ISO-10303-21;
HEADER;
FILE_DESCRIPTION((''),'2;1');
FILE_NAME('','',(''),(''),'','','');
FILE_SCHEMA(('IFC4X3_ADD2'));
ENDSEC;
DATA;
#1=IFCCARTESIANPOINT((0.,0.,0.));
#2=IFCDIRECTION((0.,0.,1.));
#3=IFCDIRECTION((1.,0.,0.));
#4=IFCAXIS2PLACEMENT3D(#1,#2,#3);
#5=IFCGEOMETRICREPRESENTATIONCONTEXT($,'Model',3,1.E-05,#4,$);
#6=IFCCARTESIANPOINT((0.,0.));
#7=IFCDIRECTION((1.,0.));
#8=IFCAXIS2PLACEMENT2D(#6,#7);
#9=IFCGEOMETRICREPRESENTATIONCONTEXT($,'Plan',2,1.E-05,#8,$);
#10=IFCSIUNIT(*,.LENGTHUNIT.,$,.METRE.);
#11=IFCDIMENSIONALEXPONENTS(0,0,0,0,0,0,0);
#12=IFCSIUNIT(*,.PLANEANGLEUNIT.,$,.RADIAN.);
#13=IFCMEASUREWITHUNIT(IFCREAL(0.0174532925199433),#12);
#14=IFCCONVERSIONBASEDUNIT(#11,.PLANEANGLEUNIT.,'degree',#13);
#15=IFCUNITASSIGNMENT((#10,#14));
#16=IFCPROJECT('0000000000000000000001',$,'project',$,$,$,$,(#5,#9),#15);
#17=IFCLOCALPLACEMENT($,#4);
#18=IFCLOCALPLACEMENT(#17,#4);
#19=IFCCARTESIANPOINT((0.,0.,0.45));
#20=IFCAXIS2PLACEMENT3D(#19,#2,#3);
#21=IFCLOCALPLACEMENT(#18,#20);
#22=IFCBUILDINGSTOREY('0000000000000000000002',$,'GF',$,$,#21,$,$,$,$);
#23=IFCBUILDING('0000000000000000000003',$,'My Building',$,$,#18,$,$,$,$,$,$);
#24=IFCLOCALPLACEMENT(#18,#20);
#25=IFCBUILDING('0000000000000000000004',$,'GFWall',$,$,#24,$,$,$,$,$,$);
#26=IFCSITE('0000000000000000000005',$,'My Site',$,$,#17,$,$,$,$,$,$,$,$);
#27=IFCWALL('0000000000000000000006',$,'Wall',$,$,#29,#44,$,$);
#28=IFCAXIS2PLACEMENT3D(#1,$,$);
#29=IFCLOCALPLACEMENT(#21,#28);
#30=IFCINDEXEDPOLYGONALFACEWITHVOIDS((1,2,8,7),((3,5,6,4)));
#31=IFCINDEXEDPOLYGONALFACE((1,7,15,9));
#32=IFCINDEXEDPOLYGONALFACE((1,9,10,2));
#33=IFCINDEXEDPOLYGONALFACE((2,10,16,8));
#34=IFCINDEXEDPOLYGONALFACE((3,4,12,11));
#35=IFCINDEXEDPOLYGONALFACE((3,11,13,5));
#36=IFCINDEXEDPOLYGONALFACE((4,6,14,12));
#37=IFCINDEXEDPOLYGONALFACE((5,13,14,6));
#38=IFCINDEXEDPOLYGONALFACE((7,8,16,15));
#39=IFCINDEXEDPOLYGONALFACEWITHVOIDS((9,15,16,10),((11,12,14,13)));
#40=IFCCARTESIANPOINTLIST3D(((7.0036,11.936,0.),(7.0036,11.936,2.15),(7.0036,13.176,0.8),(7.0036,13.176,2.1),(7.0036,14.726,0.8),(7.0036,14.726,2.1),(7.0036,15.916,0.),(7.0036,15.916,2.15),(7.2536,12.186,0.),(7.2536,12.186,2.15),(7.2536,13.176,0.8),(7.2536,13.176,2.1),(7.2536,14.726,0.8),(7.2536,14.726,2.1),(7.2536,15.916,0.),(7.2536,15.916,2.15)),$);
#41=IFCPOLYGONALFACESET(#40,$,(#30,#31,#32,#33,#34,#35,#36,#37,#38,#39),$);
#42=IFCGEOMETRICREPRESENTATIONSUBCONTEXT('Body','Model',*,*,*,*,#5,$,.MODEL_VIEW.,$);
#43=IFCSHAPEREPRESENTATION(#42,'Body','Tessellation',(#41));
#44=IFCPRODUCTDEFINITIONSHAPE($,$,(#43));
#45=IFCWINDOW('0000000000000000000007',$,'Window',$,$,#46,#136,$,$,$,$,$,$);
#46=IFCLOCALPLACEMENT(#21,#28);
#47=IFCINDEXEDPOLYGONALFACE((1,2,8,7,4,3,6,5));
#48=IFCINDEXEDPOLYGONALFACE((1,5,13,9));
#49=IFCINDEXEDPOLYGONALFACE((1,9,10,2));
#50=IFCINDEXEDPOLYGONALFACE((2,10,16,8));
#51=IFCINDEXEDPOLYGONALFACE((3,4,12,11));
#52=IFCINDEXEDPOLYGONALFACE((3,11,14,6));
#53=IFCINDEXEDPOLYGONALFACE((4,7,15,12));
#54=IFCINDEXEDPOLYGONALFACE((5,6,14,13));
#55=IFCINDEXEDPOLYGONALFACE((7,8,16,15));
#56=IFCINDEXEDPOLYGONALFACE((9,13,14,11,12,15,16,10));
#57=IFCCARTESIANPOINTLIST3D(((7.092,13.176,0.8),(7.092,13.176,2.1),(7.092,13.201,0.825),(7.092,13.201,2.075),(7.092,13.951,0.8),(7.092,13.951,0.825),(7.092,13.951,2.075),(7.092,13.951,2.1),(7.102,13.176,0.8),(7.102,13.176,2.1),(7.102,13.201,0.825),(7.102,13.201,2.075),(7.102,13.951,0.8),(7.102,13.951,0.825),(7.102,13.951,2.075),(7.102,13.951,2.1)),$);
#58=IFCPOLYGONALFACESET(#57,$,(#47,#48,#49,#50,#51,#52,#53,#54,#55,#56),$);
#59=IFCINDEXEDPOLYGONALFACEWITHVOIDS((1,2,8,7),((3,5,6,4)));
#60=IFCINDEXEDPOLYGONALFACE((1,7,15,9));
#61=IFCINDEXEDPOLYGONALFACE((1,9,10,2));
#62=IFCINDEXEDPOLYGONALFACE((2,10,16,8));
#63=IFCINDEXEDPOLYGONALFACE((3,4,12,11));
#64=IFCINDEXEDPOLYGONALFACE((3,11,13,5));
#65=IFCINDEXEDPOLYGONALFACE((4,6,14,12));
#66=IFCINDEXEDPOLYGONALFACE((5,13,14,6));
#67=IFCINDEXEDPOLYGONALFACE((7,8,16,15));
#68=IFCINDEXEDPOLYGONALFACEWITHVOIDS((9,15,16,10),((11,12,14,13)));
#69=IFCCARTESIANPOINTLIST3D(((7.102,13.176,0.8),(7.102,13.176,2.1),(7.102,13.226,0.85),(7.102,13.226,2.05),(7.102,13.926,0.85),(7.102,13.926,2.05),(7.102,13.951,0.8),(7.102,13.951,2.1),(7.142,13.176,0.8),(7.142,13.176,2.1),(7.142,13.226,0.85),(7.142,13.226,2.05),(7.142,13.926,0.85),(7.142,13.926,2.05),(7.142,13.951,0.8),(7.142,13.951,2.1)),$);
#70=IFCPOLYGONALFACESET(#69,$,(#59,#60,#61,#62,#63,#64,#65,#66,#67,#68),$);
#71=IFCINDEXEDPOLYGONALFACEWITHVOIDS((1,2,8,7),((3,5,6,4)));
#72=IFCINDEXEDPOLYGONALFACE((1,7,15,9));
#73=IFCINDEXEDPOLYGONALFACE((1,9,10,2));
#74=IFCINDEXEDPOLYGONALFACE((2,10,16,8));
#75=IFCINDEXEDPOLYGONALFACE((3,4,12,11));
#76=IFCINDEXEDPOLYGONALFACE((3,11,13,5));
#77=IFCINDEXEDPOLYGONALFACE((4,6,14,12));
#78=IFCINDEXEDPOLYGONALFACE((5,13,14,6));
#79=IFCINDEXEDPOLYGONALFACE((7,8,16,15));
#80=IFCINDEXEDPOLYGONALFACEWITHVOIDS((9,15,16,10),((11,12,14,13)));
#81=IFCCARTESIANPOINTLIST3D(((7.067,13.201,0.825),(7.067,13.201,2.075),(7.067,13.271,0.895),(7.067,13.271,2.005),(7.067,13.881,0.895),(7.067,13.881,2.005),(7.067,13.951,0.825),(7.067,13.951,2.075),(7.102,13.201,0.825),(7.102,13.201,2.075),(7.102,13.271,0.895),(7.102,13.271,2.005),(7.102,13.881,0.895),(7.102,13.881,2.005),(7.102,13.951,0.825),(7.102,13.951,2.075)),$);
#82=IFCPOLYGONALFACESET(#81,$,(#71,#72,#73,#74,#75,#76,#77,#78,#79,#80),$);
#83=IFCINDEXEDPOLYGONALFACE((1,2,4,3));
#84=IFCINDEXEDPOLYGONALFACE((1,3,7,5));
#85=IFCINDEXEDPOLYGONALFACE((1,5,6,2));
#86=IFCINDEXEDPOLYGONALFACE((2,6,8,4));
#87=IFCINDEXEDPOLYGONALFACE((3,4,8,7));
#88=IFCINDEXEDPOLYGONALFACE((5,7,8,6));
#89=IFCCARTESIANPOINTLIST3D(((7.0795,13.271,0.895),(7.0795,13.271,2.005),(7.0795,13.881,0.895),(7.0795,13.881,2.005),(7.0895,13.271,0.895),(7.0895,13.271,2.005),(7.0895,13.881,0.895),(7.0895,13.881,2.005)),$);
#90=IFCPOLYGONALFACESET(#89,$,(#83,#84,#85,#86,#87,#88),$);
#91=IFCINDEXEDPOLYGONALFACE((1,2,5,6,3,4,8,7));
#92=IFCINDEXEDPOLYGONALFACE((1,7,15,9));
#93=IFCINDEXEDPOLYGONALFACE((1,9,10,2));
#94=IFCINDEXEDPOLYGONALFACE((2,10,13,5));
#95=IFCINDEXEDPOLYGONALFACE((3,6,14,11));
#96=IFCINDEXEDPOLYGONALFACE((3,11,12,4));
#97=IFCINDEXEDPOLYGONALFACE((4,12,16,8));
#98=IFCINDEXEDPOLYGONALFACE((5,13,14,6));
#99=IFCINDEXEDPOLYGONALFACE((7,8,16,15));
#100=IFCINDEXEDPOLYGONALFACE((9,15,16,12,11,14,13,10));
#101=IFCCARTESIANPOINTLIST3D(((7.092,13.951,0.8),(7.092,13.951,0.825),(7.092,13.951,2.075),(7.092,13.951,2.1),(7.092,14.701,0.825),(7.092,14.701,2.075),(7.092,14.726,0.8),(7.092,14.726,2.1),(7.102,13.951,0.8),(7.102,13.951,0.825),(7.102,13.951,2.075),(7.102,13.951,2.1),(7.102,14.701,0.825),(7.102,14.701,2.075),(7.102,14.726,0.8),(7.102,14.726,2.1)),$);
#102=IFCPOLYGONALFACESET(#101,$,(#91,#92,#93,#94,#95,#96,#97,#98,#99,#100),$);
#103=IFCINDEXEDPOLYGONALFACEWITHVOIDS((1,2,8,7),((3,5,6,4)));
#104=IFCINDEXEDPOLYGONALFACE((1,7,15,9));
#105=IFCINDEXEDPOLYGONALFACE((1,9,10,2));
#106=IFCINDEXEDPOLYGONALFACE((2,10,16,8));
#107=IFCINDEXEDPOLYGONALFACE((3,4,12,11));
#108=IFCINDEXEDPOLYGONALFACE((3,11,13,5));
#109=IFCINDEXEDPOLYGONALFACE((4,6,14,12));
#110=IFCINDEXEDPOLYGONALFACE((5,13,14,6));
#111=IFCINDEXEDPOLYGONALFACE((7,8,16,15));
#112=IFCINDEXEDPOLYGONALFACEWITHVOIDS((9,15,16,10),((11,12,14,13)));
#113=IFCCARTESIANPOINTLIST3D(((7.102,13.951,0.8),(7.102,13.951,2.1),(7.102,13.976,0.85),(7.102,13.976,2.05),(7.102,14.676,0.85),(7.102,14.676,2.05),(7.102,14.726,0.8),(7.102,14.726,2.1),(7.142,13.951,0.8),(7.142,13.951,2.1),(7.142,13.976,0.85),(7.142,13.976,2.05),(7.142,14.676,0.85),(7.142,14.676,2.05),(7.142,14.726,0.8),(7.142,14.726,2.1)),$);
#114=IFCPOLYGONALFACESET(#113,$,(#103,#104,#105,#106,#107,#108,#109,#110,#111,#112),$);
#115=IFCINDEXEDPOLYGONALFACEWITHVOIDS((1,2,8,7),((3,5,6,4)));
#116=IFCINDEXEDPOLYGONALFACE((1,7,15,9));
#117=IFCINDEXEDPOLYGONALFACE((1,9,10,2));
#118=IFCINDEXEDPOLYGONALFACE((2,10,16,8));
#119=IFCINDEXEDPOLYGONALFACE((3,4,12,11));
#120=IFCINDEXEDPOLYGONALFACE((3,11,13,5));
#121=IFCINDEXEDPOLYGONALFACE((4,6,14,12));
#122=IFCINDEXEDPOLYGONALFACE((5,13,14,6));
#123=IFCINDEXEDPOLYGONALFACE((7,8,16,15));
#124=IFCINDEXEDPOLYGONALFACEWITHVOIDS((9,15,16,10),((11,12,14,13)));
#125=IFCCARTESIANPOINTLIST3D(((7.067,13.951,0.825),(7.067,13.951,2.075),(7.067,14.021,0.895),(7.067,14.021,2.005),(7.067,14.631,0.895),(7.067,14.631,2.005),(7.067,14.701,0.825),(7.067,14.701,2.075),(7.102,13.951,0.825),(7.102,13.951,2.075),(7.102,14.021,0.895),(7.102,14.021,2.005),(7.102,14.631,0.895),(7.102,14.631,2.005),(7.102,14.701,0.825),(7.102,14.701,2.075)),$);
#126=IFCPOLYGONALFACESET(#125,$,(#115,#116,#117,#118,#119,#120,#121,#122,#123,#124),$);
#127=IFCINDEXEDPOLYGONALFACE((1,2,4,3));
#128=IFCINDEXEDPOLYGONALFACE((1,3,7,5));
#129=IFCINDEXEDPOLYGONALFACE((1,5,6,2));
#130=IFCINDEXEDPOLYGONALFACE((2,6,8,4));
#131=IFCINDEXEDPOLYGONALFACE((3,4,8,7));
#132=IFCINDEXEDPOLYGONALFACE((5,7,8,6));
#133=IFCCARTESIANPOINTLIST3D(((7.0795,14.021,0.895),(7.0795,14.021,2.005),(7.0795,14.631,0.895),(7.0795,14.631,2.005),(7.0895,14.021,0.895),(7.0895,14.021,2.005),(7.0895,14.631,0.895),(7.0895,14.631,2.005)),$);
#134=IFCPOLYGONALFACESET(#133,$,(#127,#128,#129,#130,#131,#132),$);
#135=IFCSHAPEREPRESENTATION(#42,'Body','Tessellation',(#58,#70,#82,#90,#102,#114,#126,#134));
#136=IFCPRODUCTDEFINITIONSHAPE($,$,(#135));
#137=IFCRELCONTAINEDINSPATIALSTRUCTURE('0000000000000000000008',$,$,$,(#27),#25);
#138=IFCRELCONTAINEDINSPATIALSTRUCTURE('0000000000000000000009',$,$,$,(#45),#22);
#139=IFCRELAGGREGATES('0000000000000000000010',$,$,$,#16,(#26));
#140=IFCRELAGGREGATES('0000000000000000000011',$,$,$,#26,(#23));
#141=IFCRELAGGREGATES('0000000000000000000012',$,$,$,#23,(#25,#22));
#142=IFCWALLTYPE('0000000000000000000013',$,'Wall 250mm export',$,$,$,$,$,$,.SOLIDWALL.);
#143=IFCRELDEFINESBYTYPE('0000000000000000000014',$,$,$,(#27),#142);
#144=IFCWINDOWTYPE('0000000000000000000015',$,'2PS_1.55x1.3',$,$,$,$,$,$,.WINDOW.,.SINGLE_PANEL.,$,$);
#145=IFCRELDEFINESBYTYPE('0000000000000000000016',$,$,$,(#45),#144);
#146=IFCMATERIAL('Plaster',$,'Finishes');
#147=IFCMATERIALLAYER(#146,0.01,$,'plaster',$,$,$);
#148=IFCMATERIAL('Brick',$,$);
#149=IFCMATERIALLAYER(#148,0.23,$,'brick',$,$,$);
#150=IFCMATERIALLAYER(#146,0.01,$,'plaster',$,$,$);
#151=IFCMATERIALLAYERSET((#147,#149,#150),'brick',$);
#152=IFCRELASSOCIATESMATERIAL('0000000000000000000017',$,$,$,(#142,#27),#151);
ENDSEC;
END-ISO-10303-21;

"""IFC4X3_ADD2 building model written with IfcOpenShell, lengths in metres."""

from ifc_helpers import new_model, entity, si_unit, converted_unit, frame, origin_with_axes, origin_2d_with_axis, place, context, subcontext, project, spatial, line, indexed_curve, outline, extrude, shape, source, transform, mapped, material, layer, layer_set, layer_usage, type_object, type_shapes, element, fill, save


model = new_model("IFC4X3_ADD2")

# Units and contexts
model_context = context("Model", 3, precision=1e-05, world=origin_with_axes())
plan_context = context("Plan", 2, precision=1e-05, world=origin_2d_with_axis())
body_context_1 = subcontext(model_context, "Body", "Model", "MODEL_VIEW")
body_context_2 = subcontext(plan_context, "Body", "Plan", "PLAN_VIEW")
ifc_project = project(units=[si_unit("LENGTHUNIT", "METRE"), converted_unit("PLANEANGLEUNIT", "degree", entity("IfcReal", 0.0174532925199433), si_unit("PLANEANGLEUNIT", "RADIAN"), dimensions=[0, 0, 0, 0, 0, 0, 0])], contexts=[model_context, plan_context])

# Site, buildings
site_placement = place(None, origin_with_axes())
site = spatial("IfcSite", under=ifc_project, at=site_placement, Name="My Site")
building_1_placement = place(site_placement, origin_with_axes())
building_1 = spatial("IfcBuilding", under=site, at=building_1_placement, Name="My Building")
building_2_placement = place(building_1_placement, frame((0.0, 0.0, 0.45), z_axis=(0.0, 0.0, 1.0), x_axis=(1.0, 0.0, 0.0)))
building_2 = spatial("IfcBuilding", under=building_1, at=building_2_placement, Name="GFWall")

# Shared definitions
ifc_material_1 = material(Name="Plaster", Category="Finishes")

# Shared definitions
storey_placement = place(building_1_placement, frame((0.0, 0.0, 0.45), z_axis=(0.0, 0.0, 1.0), x_axis=(1.0, 0.0, 0.0)))
storey = spatial("IfcBuildingStorey", under=building_1, at=storey_placement, Name="GF")

# Shared definitions
ifc_layer_1 = layer(ifc_material_1, 0.01, Name="plaster")
ifc_material_2 = material(Name="Brick")
ifc_layer_2 = layer(ifc_material_2, 0.23, Name="brick")
ifc_layer_3 = layer(ifc_material_1, 0.01, Name="plaster")
ifc_layer_set_1 = layer_set([ifc_layer_1, ifc_layer_2, ifc_layer_3], Name="brick")
wall_type_1 = type_object("IfcWallType", Name="Wall 250mm export", PredefinedType="SOLIDWALL", material=ifc_layer_set_1)

# Wall, opening, window
ifc_layer_usage_1 = layer_usage(ifc_layer_set_1, "AXIS2", "POSITIVE", 0.0)
wall_1_placement = place(building_2_placement, frame((7.2536, 11.936, 0.0), z_axis=(0.0, 0.0, 1.0), x_axis=(0.0, 1.0, 0.0)))
wall_1 = element("IfcWall", 1, at=wall_1_placement, inside=building_2, type_object=wall_type_1, material=ifc_layer_usage_1, Name="Wall", context=body_context_1, shape_type="SweptSolid", body=[
    extrude(outline(indexed_curve([(0.25, 0.0), (0.0, 0.25), (3.98, 0.25), (3.98, 0.0)], segments=[line(1, 2, 3, 4, 1)])), origin_with_axes(), (0.0, 0.0, 1.0), 2.15),
])
shared_shape_1 = source(origin_with_axes(), body_context_1, "Body", "SweptSolid", [
    extrude(outline(indexed_curve([(0.0, 0.0), (1.55, 0.0), (1.55, 1.3), (0.0, 1.3)], segments=[line(1, 2, 3, 4, 1)])), frame((0.0, -0.6, 0.0), z_axis=(0.0, -1.0, 0.0), x_axis=(1.0, 0.0, 0.0)), (0.0, 0.0, -1.0), 1.2),
])
opening_1_placement = place(wall_1_placement, frame((1.24, 0.0616, 0.8), z_axis=(0.0, 0.0, 1.0), x_axis=(1.0, 0.0, 0.0)))
opening_1 = element("IfcOpeningElement", 2, at=opening_1_placement, cuts=wall_1, PredefinedType="OPENING", context=body_context_1, shape_type="MappedRepresentation", body=[
    mapped(shared_shape_1, transform((0.0, 0.0, 0.0), x_axis=(1.0, 0.0, 0.0), y_axis=(0.0, 1.0, 0.0), z_axis=(0.0, 0.0, 1.0), scale=1.0)),
])
window_type_1 = type_object("IfcWindowType", Name="2PS_1.55x1.3", PartitioningType="SINGLE_PANEL", PredefinedType="WINDOW")
shared_shape_2 = source(origin_with_axes(), body_context_1, "Body", "SweptSolid", [
    extrude(outline(indexed_curve([(0.775, 0.0), (0.0, 0.0), (0.0, 1.3), (0.775, 1.3), (0.775, 1.275), (0.025, 1.275), (0.025, 0.025), (0.775, 0.025)], segments=[line(1, 2, 3, 4, 5, 6, 7, 8, 1)])), frame((0.0, 0.09, 0.0), z_axis=(0.0, -1.0, 0.0), x_axis=(1.0, 0.0, 0.0)), (0.0, 0.0, -1.0), 0.01),
    extrude(outline(indexed_curve([(0.0, 0.0), (0.775, 0.0), (0.775, 1.3), (0.0, 1.3)], segments=[line(1, 2, 3, 4, 1)]), holes=[indexed_curve([(0.05, 0.05), (0.75, 0.05), (0.75, 1.25), (0.05, 1.25)], segments=[line(1, 2, 3, 4, 1)])]), frame((0.0, 0.05, 0.0), z_axis=(0.0, -1.0, 0.0), x_axis=(1.0, 0.0, 0.0)), (0.0, 0.0, -1.0), 0.04),
    extrude(outline(indexed_curve([(0.0, 0.0), (0.75, 0.0), (0.75, 1.25), (0.0, 1.25)], segments=[line(1, 2, 3, 4, 1)]), holes=[indexed_curve([(0.07, 0.07), (0.68, 0.07), (0.68, 1.18), (0.07, 1.18)], segments=[line(1, 2, 3, 4, 1)])]), frame((0.025, 0.09, 0.025), z_axis=(0.0, -1.0, 0.0), x_axis=(1.0, 0.0, 0.0)), (0.0, 0.0, -1.0), 0.035),
    extrude(outline(indexed_curve([(0.07, 0.07), (0.68, 0.07), (0.68, 1.18), (0.07, 1.18)], segments=[line(1, 2, 3, 4, 1)])), frame((0.025, 0.1025, 0.025), z_axis=(0.0, -1.0, 0.0), x_axis=(1.0, 0.0, 0.0)), (0.0, 0.0, -1.0), 0.01),
    extrude(outline(indexed_curve([(0.0, 1.3), (0.775, 1.3), (0.775, 0.0), (0.0, 0.0), (0.0, 0.025), (0.75, 0.025), (0.75, 1.275), (0.0, 1.275)], segments=[line(1, 2, 3, 4, 5, 6, 7, 8, 1)])), frame((0.775, 0.09, 0.0), z_axis=(0.0, -1.0, 0.0), x_axis=(1.0, 0.0, 0.0)), (0.0, 0.0, -1.0), 0.01),
    extrude(outline(indexed_curve([(0.0, 0.0), (0.775, 0.0), (0.775, 1.3), (0.0, 1.3)], segments=[line(1, 2, 3, 4, 1)]), holes=[indexed_curve([(0.025, 0.05), (0.725, 0.05), (0.725, 1.25), (0.025, 1.25)], segments=[line(1, 2, 3, 4, 1)])]), frame((0.775, 0.05, 0.0), z_axis=(0.0, -1.0, 0.0), x_axis=(1.0, 0.0, 0.0)), (0.0, 0.0, -1.0), 0.04),
    extrude(outline(indexed_curve([(0.0, 0.0), (0.75, 0.0), (0.75, 1.25), (0.0, 1.25)], segments=[line(1, 2, 3, 4, 1)]), holes=[indexed_curve([(0.07, 0.07), (0.68, 0.07), (0.68, 1.18), (0.07, 1.18)], segments=[line(1, 2, 3, 4, 1)])]), frame((0.775, 0.09, 0.025), z_axis=(0.0, -1.0, 0.0), x_axis=(1.0, 0.0, 0.0)), (0.0, 0.0, -1.0), 0.035),
    extrude(outline(indexed_curve([(0.07, 0.07), (0.68, 0.07), (0.68, 1.18), (0.07, 1.18)], segments=[line(1, 2, 3, 4, 1)])), frame((0.775, 0.1025, 0.025), z_axis=(0.0, -1.0, 0.0), x_axis=(1.0, 0.0, 0.0)), (0.0, 0.0, -1.0), 0.01),
])
shared_shape_3 = source(origin_with_axes(), body_context_2, "Body", "Curve2D", [
    entity("IfcIndexedPolyCurve", entity("IfcCartesianPointList2D", [[0.05, 0.05], [0.75, 0.05]])),
    entity("IfcIndexedPolyCurve", entity("IfcCartesianPointList2D", [[0.0, 0.1], [0.025, 0.1], [0.025, 0.09], [0.05, 0.09], [0.05, 0.05], [0.0, 0.05]]), [entity("IfcLineIndex", [1, 2, 3, 4, 5, 6, 1])]),
    entity("IfcIndexedPolyCurve", entity("IfcCartesianPointList2D", [[0.775, 0.1], [0.775, 0.1], [0.775, 0.09], [0.75, 0.09], [0.75, 0.05], [0.775, 0.05]])),
    entity("IfcIndexedPolyCurve", entity("IfcCartesianPointList2D", [[0.025, 0.09], [0.095, 0.09], [0.095, 0.125], [0.025, 0.125]]), [entity("IfcLineIndex", [1, 2, 3, 4, 1])]),
    entity("IfcIndexedPolyCurve", entity("IfcCartesianPointList2D", [[0.775, 0.09], [0.705, 0.09], [0.705, 0.125], [0.775, 0.125]]), [entity("IfcLineIndex", [1, 2, 3, 4, 1])]),
    entity("IfcIndexedPolyCurve", entity("IfcCartesianPointList2D", [[0.095, 0.09], [0.705, 0.09]])),
    entity("IfcIndexedPolyCurve", entity("IfcCartesianPointList2D", [[0.095, 0.125], [0.705, 0.125]])),
    entity("IfcIndexedPolyCurve", entity("IfcCartesianPointList2D", [[0.095, 0.1075], [0.705, 0.1075]])),
    entity("IfcIndexedPolyCurve", entity("IfcCartesianPointList2D", [[0.8, 0.05], [1.5, 0.05]])),
    entity("IfcIndexedPolyCurve", entity("IfcCartesianPointList2D", [[0.775, 0.1], [0.775, 0.1], [0.775, 0.09], [0.8, 0.09], [0.8, 0.05], [0.775, 0.05]])),
    entity("IfcIndexedPolyCurve", entity("IfcCartesianPointList2D", [[1.55, 0.1], [1.525, 0.1], [1.525, 0.09], [1.5, 0.09], [1.5, 0.05], [1.55, 0.05]]), [entity("IfcLineIndex", [1, 2, 3, 4, 5, 6, 1])]),
    entity("IfcIndexedPolyCurve", entity("IfcCartesianPointList2D", [[0.775, 0.09], [0.845, 0.09], [0.845, 0.125], [0.775, 0.125]]), [entity("IfcLineIndex", [1, 2, 3, 4, 1])]),
    entity("IfcIndexedPolyCurve", entity("IfcCartesianPointList2D", [[1.525, 0.09], [1.455, 0.09], [1.455, 0.125], [1.525, 0.125]]), [entity("IfcLineIndex", [1, 2, 3, 4, 1])]),
    entity("IfcIndexedPolyCurve", entity("IfcCartesianPointList2D", [[0.845, 0.09], [1.455, 0.09]])),
    entity("IfcIndexedPolyCurve", entity("IfcCartesianPointList2D", [[0.845, 0.125], [1.455, 0.125]])),
    entity("IfcIndexedPolyCurve", entity("IfcCartesianPointList2D", [[0.845, 0.1075], [1.455, 0.1075]])),
])
type_shapes(window_type_1, [shared_shape_2, shared_shape_3])
window_1_placement = place(opening_1_placement, frame((0.0, 0.0, 0.0), z_axis=(0.0, 0.0, 1.0), x_axis=(1.0, 0.0, 0.0)))
window_1 = element("IfcWindow", 3, at=window_1_placement, inside=storey, type_object=window_type_1, Name="Window", shapes=[
    shape(body_context_1, "Body", "MappedRepresentation", [mapped(shared_shape_2, transform((0.0, 0.0, 0.0), x_axis=(1.0, 0.0, 0.0), y_axis=(0.0, 1.0, 0.0), z_axis=(0.0, 0.0, 1.0), scale=1.0))]),
    shape(body_context_2, "Body", "MappedRepresentation", [mapped(shared_shape_3, transform((0.0, 0.0, 0.0), x_axis=(1.0, 0.0, 0.0), y_axis=(0.0, 1.0, 0.0), z_axis=(0.0, 0.0, 1.0), scale=1.0))]),
])
fill(opening_1, window_1)

save(model, "model.ifc")
